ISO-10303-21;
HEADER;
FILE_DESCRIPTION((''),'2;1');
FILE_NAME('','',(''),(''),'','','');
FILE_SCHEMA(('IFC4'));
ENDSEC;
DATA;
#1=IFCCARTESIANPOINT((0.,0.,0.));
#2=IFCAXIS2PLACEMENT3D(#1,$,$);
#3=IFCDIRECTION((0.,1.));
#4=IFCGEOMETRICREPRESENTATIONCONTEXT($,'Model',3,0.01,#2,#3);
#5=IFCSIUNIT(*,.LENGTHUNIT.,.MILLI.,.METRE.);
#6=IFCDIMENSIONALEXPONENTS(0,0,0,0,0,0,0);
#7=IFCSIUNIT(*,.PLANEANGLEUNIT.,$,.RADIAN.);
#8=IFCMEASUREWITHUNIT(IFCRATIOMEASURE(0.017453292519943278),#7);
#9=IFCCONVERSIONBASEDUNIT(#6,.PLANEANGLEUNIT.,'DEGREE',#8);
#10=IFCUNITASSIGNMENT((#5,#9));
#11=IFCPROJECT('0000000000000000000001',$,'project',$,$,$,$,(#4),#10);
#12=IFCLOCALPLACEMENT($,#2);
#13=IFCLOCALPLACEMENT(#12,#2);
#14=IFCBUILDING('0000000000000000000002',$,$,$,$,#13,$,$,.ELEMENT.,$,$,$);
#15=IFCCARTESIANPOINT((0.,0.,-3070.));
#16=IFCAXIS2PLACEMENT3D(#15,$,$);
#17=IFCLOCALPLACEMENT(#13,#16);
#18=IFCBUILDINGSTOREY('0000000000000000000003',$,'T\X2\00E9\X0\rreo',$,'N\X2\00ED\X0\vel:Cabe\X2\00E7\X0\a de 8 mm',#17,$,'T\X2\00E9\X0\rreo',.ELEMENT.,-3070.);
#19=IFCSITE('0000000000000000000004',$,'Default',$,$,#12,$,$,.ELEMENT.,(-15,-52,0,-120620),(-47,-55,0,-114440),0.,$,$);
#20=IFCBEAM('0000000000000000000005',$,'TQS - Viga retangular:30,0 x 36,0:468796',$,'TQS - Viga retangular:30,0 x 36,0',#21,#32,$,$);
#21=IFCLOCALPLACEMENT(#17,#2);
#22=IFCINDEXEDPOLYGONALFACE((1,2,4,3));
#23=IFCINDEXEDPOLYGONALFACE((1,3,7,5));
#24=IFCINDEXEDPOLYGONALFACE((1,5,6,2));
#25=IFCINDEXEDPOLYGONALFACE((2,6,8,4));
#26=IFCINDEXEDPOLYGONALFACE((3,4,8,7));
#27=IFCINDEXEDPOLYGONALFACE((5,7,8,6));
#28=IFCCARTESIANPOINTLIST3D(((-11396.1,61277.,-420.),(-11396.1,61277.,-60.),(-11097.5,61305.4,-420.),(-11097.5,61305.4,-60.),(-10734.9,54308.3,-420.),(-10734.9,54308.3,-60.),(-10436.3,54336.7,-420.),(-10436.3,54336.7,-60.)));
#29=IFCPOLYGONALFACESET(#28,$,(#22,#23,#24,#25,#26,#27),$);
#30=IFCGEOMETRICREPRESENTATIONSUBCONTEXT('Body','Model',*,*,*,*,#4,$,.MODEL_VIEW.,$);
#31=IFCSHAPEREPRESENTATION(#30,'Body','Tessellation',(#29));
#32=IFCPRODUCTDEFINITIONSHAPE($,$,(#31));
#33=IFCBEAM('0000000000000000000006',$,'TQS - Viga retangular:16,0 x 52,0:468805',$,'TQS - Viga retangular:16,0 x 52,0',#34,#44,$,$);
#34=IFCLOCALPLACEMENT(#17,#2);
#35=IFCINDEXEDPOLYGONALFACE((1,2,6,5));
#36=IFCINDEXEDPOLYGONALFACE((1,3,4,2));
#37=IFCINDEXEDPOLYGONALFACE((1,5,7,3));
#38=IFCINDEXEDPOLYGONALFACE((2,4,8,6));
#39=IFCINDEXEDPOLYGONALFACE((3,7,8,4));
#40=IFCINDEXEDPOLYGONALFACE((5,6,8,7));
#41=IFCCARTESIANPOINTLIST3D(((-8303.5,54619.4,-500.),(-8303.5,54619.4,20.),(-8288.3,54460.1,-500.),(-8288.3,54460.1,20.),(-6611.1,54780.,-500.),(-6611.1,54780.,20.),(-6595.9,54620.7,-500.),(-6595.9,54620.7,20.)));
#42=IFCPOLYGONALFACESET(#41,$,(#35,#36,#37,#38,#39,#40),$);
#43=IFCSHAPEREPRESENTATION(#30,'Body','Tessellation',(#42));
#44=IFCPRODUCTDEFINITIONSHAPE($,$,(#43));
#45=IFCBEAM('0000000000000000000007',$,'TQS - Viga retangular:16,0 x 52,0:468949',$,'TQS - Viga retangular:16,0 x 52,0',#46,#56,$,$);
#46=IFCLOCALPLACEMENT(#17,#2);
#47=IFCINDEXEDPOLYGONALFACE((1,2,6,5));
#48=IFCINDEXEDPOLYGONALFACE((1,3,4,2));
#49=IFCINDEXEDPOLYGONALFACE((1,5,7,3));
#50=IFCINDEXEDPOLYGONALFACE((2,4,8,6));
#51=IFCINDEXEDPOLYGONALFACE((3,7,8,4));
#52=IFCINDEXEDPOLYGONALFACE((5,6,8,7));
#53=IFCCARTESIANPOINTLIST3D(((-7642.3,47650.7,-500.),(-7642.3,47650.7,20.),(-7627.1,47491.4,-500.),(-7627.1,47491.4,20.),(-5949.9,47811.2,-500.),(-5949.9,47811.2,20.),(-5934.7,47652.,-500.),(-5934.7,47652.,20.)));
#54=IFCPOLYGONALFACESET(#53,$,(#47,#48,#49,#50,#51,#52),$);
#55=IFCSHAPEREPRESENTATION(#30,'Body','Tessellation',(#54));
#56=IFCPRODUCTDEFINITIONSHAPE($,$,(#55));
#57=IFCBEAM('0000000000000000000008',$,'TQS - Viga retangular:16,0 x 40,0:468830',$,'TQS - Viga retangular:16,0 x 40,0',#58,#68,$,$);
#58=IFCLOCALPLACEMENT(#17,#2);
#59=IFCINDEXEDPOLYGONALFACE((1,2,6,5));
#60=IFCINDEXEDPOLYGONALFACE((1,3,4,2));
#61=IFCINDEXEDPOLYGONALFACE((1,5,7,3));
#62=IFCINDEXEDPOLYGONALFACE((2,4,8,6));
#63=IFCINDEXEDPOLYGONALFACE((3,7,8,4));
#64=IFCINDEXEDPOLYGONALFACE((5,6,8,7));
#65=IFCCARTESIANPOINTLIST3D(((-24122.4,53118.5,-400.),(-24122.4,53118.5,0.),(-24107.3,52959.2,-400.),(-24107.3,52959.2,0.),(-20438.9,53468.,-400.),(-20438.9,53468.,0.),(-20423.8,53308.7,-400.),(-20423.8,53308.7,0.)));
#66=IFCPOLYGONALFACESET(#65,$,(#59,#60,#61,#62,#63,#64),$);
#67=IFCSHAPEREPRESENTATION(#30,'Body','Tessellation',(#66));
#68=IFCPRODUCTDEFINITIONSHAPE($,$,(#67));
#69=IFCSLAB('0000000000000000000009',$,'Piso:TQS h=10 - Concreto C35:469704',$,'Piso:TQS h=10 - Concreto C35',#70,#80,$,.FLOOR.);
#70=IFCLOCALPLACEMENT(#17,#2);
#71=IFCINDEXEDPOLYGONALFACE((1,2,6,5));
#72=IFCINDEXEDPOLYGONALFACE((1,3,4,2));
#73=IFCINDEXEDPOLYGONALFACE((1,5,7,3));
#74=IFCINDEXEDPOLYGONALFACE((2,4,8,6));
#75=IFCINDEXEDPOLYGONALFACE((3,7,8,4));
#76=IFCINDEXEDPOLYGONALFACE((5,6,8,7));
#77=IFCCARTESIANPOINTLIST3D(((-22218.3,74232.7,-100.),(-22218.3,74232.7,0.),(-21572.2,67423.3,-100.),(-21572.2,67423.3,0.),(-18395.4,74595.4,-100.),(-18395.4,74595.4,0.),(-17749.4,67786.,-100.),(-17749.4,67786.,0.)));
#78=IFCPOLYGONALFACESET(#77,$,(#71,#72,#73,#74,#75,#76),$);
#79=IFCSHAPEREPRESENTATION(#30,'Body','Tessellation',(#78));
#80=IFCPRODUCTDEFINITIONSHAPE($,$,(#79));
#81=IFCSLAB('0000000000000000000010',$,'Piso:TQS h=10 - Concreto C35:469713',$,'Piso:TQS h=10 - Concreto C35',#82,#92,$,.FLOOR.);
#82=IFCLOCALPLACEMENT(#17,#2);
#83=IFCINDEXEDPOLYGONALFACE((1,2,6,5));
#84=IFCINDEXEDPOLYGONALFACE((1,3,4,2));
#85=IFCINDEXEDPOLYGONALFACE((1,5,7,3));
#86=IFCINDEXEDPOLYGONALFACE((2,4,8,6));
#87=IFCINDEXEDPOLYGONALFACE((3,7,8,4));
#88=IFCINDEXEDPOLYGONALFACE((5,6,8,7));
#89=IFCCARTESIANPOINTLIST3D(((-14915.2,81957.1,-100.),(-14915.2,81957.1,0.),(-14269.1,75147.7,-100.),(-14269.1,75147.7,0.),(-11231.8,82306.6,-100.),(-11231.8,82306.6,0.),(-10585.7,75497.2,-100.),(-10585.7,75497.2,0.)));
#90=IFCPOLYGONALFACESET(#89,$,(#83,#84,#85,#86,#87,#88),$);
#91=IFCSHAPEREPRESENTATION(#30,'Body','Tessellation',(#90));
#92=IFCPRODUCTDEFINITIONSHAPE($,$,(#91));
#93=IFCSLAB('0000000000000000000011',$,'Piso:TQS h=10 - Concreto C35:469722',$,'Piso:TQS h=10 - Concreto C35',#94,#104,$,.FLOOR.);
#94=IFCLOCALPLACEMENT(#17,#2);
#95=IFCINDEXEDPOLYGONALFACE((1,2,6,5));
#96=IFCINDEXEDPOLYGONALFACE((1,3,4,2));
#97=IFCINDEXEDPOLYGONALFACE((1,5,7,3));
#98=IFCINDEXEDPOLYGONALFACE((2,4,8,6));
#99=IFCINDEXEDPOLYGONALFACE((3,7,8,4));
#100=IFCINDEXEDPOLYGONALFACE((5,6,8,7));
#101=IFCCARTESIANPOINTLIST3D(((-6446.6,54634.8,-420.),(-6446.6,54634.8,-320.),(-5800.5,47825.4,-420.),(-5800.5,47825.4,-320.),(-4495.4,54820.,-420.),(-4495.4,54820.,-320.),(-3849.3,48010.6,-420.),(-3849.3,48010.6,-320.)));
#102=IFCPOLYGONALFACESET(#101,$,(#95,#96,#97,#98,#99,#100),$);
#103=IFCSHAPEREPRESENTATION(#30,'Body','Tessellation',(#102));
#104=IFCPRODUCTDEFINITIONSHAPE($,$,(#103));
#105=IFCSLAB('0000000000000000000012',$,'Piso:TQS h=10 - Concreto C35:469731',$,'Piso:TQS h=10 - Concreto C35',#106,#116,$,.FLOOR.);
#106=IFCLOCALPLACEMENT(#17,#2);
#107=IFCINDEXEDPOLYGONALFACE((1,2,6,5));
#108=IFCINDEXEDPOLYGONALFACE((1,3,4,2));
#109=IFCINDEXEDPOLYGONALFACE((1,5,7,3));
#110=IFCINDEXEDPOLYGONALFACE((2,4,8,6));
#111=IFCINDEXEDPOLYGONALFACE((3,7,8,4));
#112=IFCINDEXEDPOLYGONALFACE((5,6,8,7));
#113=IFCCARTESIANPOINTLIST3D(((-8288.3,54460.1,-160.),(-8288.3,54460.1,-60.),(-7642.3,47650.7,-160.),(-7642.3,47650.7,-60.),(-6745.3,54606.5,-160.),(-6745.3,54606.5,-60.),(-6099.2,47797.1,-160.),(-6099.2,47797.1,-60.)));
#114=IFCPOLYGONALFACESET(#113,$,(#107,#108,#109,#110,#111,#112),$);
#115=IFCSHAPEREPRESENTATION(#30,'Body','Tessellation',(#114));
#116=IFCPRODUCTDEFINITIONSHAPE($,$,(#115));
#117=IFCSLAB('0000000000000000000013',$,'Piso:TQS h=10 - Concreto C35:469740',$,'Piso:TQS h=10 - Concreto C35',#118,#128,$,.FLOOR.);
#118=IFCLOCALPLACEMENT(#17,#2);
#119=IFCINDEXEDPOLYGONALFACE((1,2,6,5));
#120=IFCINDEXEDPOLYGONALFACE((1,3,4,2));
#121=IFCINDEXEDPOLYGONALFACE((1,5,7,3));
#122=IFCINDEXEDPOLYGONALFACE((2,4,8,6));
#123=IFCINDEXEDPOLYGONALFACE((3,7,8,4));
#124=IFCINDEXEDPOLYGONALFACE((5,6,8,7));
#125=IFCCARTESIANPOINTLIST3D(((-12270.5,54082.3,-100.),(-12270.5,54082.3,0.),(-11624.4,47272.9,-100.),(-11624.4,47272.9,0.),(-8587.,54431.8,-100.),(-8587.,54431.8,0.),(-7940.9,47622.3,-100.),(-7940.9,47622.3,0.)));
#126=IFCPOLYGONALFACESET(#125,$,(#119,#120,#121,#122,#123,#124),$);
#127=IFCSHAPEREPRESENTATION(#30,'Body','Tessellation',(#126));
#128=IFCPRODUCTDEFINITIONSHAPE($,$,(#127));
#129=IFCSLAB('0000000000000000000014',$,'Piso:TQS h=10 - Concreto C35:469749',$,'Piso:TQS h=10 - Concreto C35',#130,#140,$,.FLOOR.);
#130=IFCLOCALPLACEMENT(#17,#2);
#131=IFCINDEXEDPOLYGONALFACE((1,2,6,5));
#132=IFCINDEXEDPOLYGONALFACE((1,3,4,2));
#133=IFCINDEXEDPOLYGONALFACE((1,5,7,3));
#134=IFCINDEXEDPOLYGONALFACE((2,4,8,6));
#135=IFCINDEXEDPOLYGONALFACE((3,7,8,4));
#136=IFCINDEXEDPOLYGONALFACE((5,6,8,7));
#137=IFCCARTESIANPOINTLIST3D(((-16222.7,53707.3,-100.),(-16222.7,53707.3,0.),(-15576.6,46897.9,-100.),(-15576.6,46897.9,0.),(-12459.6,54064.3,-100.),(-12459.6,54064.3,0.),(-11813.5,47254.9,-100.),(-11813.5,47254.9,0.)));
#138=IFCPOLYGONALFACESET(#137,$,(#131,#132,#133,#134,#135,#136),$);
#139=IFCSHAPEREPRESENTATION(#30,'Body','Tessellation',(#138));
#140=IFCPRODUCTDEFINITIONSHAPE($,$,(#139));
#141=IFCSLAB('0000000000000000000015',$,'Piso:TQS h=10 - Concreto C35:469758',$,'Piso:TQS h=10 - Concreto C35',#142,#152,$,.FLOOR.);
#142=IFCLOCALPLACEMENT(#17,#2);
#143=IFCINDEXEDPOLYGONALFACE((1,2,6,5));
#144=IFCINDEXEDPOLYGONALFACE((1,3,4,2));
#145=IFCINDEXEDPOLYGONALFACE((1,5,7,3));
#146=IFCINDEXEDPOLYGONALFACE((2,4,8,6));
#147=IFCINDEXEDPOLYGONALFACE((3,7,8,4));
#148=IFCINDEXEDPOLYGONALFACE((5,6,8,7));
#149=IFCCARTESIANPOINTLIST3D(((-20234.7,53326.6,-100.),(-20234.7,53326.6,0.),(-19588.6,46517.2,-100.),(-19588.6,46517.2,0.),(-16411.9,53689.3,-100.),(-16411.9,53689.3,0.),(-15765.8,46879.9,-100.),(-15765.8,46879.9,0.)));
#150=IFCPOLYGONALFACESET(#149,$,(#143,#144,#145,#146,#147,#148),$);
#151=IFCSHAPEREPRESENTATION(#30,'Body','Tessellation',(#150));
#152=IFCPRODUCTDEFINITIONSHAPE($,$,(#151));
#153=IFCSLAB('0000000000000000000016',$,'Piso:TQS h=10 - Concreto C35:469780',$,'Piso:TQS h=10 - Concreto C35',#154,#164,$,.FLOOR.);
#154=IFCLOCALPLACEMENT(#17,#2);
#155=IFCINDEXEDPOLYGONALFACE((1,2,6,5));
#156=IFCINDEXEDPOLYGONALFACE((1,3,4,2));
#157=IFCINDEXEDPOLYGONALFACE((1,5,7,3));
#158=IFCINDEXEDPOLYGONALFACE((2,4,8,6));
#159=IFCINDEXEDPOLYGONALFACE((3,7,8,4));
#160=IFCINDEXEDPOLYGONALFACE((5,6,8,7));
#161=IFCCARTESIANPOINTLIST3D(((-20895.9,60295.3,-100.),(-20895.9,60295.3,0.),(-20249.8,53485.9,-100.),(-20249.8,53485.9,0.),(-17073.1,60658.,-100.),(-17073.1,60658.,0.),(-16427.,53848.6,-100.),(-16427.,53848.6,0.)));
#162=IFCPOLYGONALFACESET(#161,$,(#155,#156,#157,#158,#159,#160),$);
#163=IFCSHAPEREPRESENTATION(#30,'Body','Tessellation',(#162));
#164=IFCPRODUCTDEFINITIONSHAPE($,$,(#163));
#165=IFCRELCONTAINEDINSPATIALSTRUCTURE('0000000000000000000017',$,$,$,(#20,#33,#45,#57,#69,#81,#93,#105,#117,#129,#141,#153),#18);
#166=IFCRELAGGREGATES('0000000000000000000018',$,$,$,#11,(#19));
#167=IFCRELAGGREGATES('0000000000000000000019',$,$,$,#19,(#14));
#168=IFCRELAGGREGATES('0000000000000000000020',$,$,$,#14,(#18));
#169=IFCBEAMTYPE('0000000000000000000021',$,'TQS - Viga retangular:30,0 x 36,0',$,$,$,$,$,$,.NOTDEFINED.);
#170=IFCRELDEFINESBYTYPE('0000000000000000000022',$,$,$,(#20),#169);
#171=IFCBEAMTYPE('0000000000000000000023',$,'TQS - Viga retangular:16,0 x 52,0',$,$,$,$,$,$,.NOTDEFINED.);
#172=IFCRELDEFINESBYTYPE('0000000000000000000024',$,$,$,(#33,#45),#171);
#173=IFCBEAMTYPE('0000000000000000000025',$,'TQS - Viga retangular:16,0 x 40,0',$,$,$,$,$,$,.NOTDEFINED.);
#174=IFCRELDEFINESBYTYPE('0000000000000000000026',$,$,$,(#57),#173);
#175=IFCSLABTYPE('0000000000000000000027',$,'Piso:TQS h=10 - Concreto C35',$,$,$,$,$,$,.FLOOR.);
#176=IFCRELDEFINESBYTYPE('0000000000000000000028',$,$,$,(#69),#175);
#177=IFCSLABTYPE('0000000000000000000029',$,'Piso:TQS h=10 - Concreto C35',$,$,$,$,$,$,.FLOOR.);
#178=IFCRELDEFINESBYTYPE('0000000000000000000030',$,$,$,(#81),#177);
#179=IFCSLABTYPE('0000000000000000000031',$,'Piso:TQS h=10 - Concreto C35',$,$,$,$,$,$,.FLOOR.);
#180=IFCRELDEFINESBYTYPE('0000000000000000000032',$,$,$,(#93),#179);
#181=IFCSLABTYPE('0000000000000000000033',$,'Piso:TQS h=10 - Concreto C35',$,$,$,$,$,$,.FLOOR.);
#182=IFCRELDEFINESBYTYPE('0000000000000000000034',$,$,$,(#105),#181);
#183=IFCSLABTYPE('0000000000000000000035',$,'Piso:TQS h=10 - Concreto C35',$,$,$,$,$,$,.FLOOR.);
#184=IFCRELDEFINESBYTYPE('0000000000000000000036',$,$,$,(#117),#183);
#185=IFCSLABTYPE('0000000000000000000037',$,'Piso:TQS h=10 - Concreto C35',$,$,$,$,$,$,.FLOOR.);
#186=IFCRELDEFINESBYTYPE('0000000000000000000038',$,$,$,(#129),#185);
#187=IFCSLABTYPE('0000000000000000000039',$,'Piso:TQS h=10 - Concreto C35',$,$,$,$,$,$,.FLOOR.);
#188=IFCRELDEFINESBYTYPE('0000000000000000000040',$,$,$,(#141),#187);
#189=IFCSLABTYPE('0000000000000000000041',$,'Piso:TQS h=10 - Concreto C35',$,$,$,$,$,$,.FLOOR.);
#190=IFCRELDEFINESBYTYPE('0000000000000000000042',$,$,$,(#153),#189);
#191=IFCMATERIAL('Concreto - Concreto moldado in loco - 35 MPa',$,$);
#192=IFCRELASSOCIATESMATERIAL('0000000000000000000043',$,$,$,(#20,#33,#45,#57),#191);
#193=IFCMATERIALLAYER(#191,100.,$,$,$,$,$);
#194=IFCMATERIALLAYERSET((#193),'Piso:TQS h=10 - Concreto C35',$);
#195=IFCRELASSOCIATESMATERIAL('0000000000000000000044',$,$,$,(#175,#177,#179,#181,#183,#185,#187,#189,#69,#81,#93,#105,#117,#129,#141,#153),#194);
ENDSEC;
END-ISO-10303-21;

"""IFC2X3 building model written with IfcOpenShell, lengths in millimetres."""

from ifc_helpers import new_model, entity, si_unit, converted_unit, direction, frame, frame_2d, origin, place, context, subcontext, project, spatial, rectangle, extrude, material, layer, layer_set, layer_usage, type_object, element, save


model = new_model("IFC2X3")

# Units and contexts
model_context = context("Model", 3, precision=0.01, world=origin(), true_north=direction((0.0, 1.0)))
body_context = subcontext(model_context, "Body", "Model", "MODEL_VIEW")
ifc_project = project(units=[si_unit("LENGTHUNIT", "METRE", prefix="MILLI"), converted_unit("PLANEANGLEUNIT", "DEGREE", entity("IfcRatioMeasure", 0.017453292519943278), si_unit("PLANEANGLEUNIT", "RADIAN"), dimensions=[0, 0, 0, 0, 0, 0, 0])], contexts=[model_context])

# Site, building, storey
site_placement = place(None, origin())
site = spatial("IfcSite", under=ifc_project, at=site_placement, Name="Default", CompositionType="ELEMENT", RefLatitude=(-15, -52, 0, -120620), RefLongitude=(-47, -55, 0, -114440), RefElevation=0.0)
building_placement = place(site_placement, origin())
building = spatial("IfcBuilding", under=site, at=building_placement, CompositionType="ELEMENT")
storey_placement = place(building_placement, frame((0.0, 0.0, -3070.0)))
storey = spatial("IfcBuildingStorey", under=building, at=storey_placement, Name="Térreo", ObjectType="Nível:Cabeça de 8 mm", LongName="Térreo", CompositionType="ELEMENT", Elevation=-3070.0)

# Beams
ifc_material_1 = material(Name="Concreto - Concreto moldado in loco - 35 MPa")
beam_type_1 = type_object("IfcBeamType", Name="TQS - Viga retangular:30,0 x 36,0", PredefinedType="NOTDEFINED")
beam_1_placement = place(storey_placement, frame((-10585.6, 54322.5, -60.0), z_axis=(0.0, 0.0, 1.0), x_axis=(-0.094456, 0.995529, 0.0)))
element("IfcBeam", 1, at=beam_1_placement, inside=storey, type_object=beam_type_1, material=ifc_material_1, Name="TQS - Viga retangular:30,0 x 36,0:468796", ObjectType="TQS - Viga retangular:30,0 x 36,0", context=body_context, shape_type="SweptSolid", body=[
    extrude(rectangle(XDim=360.0, YDim=300.0, at=frame_2d((0.0, 0.0), x_axis=(1.0, 0.0))), frame((0.0, 0.0, -180.0), z_axis=(1.0, 0.0, 0.0), x_axis=(0.0, 0.0, -1.0)), (0.0, 0.0, 1.0), 7000.0),
])
beam_type_2 = type_object("IfcBeamType", Name="TQS - Viga retangular:16,0 x 52,0", PredefinedType="NOTDEFINED")
beam_2_placement = place(storey_placement, frame((-6603.5, 54700.3, 20.0), z_axis=(0.0, 0.0, 1.0), x_axis=(-0.995529, -0.094456, 0.0)))
element("IfcBeam", 2, at=beam_2_placement, inside=storey, type_object=beam_type_2, material=ifc_material_1, Name="TQS - Viga retangular:16,0 x 52,0:468805", ObjectType="TQS - Viga retangular:16,0 x 52,0", context=body_context, shape_type="SweptSolid", body=[
    extrude(rectangle(XDim=520.0, YDim=160.0, at=frame_2d((0.0, 0.0), x_axis=(1.0, 0.0))), frame((0.0, 0.0, -260.0), z_axis=(1.0, 0.0, 0.0), x_axis=(0.0, 0.0, -1.0)), (0.0, 0.0, 1.0), 1700.0),
])
beam_3_placement = place(storey_placement, frame((-5942.3, 47731.6, 20.0), z_axis=(0.0, 0.0, 1.0), x_axis=(-0.995529, -0.094456, 0.0)))
element("IfcBeam", 3, at=beam_3_placement, inside=storey, type_object=beam_type_2, material=ifc_material_1, Name="TQS - Viga retangular:16,0 x 52,0:468949", ObjectType="TQS - Viga retangular:16,0 x 52,0", context=body_context, shape_type="SweptSolid", body=[
    extrude(rectangle(XDim=520.0, YDim=160.0, at=frame_2d((0.0, 0.0), x_axis=(1.0, 0.0))), frame((0.0, 0.0, -260.0), z_axis=(1.0, 0.0, 0.0), x_axis=(0.0, 0.0, -1.0)), (0.0, 0.0, 1.0), 1700.0),
])
beam_type_3 = type_object("IfcBeamType", Name="TQS - Viga retangular:16,0 x 40,0", PredefinedType="NOTDEFINED")
beam_4_placement = place(storey_placement, frame((-20336.8, 53397.3, 0.0), z_axis=(0.0, 0.0, 1.0), x_axis=(-0.995529, -0.094456, 0.0)))
element("IfcBeam", 4, at=beam_4_placement, inside=storey, type_object=beam_type_3, material=ifc_material_1, Name="TQS - Viga retangular:16,0 x 40,0:468830", ObjectType="TQS - Viga retangular:16,0 x 40,0", context=body_context, shape_type="SweptSolid", body=[
    extrude(rectangle(XDim=400.0, YDim=160.0, at=frame_2d((0.0, 0.0), x_axis=(1.0, 0.0))), frame((95.0, 0.0, -200.0), z_axis=(1.0, 0.0, 0.0), x_axis=(0.0, 0.0, -1.0)), (0.0, 0.0, 1.0), 3700.0),
])

# Slabs
ifc_layer = layer(ifc_material_1, 100.0)
ifc_layer_set = layer_set([ifc_layer], Name="Piso:TQS h=10 - Concreto C35")
ifc_layer_usage_1 = layer_usage(ifc_layer_set, "AXIS3", "POSITIVE", 0.0)
slab_type_1 = type_object("IfcSlabType", Name="Piso:TQS h=10 - Concreto C35", PredefinedType="FLOOR", material=ifc_layer_set)
slab_1_placement = place(storey_placement, origin())
element("IfcSlab", 5, at=slab_1_placement, inside=storey, type_object=slab_type_1, material=ifc_layer_usage_1, Name="Piso:TQS h=10 - Concreto C35:469704", ObjectType="Piso:TQS h=10 - Concreto C35", PredefinedType="FLOOR", context=body_context, shape_type="SweptSolid", body=[
    extrude(rectangle(XDim=6840.0, YDim=3840.0, at=frame_2d((0.0, 0.0), x_axis=(1.0, 0.0))), frame((-19983.8, 71009.4, 0.0), z_axis=(0.0, 0.0, -1.0), x_axis=(0.094456, -0.995529, 0.0)), (0.0, 0.0, 1.0), 100.0),
])
ifc_layer_usage_2 = layer_usage(ifc_layer_set, "AXIS3", "POSITIVE", 0.0)
slab_type_2 = type_object("IfcSlabType", Name="Piso:TQS h=10 - Concreto C35", PredefinedType="FLOOR", material=ifc_layer_set)
slab_2_placement = place(storey_placement, origin())
element("IfcSlab", 6, at=slab_2_placement, inside=storey, type_object=slab_type_2, material=ifc_layer_usage_2, Name="Piso:TQS h=10 - Concreto C35:469713", ObjectType="Piso:TQS h=10 - Concreto C35", PredefinedType="FLOOR", context=body_context, shape_type="SweptSolid", body=[
    extrude(rectangle(XDim=6840.0, YDim=3700.0, at=frame_2d((0.0, 0.0), x_axis=(1.0, 0.0))), frame((-12750.4, 78727.1, 0.0), z_axis=(0.0, 0.0, -1.0), x_axis=(0.094456, -0.995529, 0.0)), (0.0, 0.0, 1.0), 100.0),
])
ifc_layer_usage_3 = layer_usage(ifc_layer_set, "AXIS3", "POSITIVE", 0.0)
slab_type_3 = type_object("IfcSlabType", Name="Piso:TQS h=10 - Concreto C35", PredefinedType="FLOOR", material=ifc_layer_set)
slab_3_placement = place(storey_placement, origin())
element("IfcSlab", 7, at=slab_3_placement, inside=storey, type_object=slab_type_3, material=ifc_layer_usage_3, Name="Piso:TQS h=10 - Concreto C35:469722", ObjectType="Piso:TQS h=10 - Concreto C35", PredefinedType="FLOOR", context=body_context, shape_type="SweptSolid", body=[
    extrude(rectangle(XDim=1960.0, YDim=6840.0, at=frame_2d((0.0, 0.0), x_axis=(1.0, 0.0))), frame((-5148.0, 51322.7, -320.0), z_axis=(0.0, 0.0, -1.0), x_axis=(0.995529, 0.094456, 0.0)), (0.0, 0.0, 1.0), 100.0),
])
ifc_layer_usage_4 = layer_usage(ifc_layer_set, "AXIS3", "POSITIVE", 0.0)
slab_type_4 = type_object("IfcSlabType", Name="Piso:TQS h=10 - Concreto C35", PredefinedType="FLOOR", material=ifc_layer_set)
slab_4_placement = place(storey_placement, origin())
element("IfcSlab", 8, at=slab_4_placement, inside=storey, type_object=slab_type_4, material=ifc_layer_usage_4, Name="Piso:TQS h=10 - Concreto C35:469731", ObjectType="Piso:TQS h=10 - Concreto C35", PredefinedType="FLOOR", context=body_context, shape_type="SweptSolid", body=[
    extrude(rectangle(XDim=1550.0, YDim=6840.0, at=frame_2d((0.0, 0.0), x_axis=(1.0, 0.0))), frame((-7193.8, 51128.6, -60.0), z_axis=(0.0, 0.0, -1.0), x_axis=(0.995529, 0.094456, 0.0)), (0.0, 0.0, 1.0), 100.0),
])
ifc_layer_usage_5 = layer_usage(ifc_layer_set, "AXIS3", "POSITIVE", 0.0)
slab_type_5 = type_object("IfcSlabType", Name="Piso:TQS h=10 - Concreto C35", PredefinedType="FLOOR", material=ifc_layer_set)
slab_5_placement = place(storey_placement, origin())
element("IfcSlab", 9, at=slab_5_placement, inside=storey, type_object=slab_type_5, material=ifc_layer_usage_5, Name="Piso:TQS h=10 - Concreto C35:469740", ObjectType="Piso:TQS h=10 - Concreto C35", PredefinedType="FLOOR", context=body_context, shape_type="SweptSolid", body=[
    extrude(rectangle(XDim=6840.0, YDim=3700.0, at=frame_2d((0.0, 0.0), x_axis=(1.0, 0.0))), frame((-10105.7, 50852.3, 0.0), z_axis=(0.0, 0.0, -1.0), x_axis=(0.094456, -0.995529, 0.0)), (0.0, 0.0, 1.0), 100.0),
])
ifc_layer_usage_6 = layer_usage(ifc_layer_set, "AXIS3", "POSITIVE", 0.0)
slab_type_6 = type_object("IfcSlabType", Name="Piso:TQS h=10 - Concreto C35", PredefinedType="FLOOR", material=ifc_layer_set)
slab_6_placement = place(storey_placement, origin())
element("IfcSlab", 10, at=slab_6_placement, inside=storey, type_object=slab_type_6, material=ifc_layer_usage_6, Name="Piso:TQS h=10 - Concreto C35:469749", ObjectType="Piso:TQS h=10 - Concreto C35", PredefinedType="FLOOR", context=body_context, shape_type="SweptSolid", body=[
    extrude(rectangle(XDim=6840.0, YDim=3780.0, at=frame_2d((0.0, 0.0), x_axis=(1.0, 0.0))), frame((-14018.1, 50481.1, 0.0), z_axis=(0.0, 0.0, -1.0), x_axis=(0.094456, -0.995529, 0.0)), (0.0, 0.0, 1.0), 100.0),
])
ifc_layer_usage_7 = layer_usage(ifc_layer_set, "AXIS3", "POSITIVE", 0.0)
slab_type_7 = type_object("IfcSlabType", Name="Piso:TQS h=10 - Concreto C35", PredefinedType="FLOOR", material=ifc_layer_set)
slab_7_placement = place(storey_placement, origin())
element("IfcSlab", 11, at=slab_7_placement, inside=storey, type_object=slab_type_7, material=ifc_layer_usage_7, Name="Piso:TQS h=10 - Concreto C35:469758", ObjectType="Piso:TQS h=10 - Concreto C35", PredefinedType="FLOOR", context=body_context, shape_type="SweptSolid", body=[
    extrude(rectangle(XDim=6840.0, YDim=3840.0, at=frame_2d((0.0, 0.0), x_axis=(1.0, 0.0))), frame((-18000.2, 50103.3, 0.0), z_axis=(0.0, 0.0, -1.0), x_axis=(0.094456, -0.995529, 0.0)), (0.0, 0.0, 1.0), 100.0),
])
ifc_layer_usage_8 = layer_usage(ifc_layer_set, "AXIS3", "POSITIVE", 0.0)
slab_type_8 = type_object("IfcSlabType", Name="Piso:TQS h=10 - Concreto C35", PredefinedType="FLOOR", material=ifc_layer_set)
slab_8_placement = place(storey_placement, origin())
element("IfcSlab", 12, at=slab_8_placement, inside=storey, type_object=slab_type_8, material=ifc_layer_usage_8, Name="Piso:TQS h=10 - Concreto C35:469780", ObjectType="Piso:TQS h=10 - Concreto C35", PredefinedType="FLOOR", context=body_context, shape_type="SweptSolid", body=[
    extrude(rectangle(XDim=6840.0, YDim=3840.0, at=frame_2d((0.0, 0.0), x_axis=(1.0, 0.0))), frame((-18661.4, 57072.0, 0.0), z_axis=(0.0, 0.0, -1.0), x_axis=(0.094456, -0.995529, 0.0)), (0.0, 0.0, 1.0), 100.0),
])

save(model, "model.ifc")
